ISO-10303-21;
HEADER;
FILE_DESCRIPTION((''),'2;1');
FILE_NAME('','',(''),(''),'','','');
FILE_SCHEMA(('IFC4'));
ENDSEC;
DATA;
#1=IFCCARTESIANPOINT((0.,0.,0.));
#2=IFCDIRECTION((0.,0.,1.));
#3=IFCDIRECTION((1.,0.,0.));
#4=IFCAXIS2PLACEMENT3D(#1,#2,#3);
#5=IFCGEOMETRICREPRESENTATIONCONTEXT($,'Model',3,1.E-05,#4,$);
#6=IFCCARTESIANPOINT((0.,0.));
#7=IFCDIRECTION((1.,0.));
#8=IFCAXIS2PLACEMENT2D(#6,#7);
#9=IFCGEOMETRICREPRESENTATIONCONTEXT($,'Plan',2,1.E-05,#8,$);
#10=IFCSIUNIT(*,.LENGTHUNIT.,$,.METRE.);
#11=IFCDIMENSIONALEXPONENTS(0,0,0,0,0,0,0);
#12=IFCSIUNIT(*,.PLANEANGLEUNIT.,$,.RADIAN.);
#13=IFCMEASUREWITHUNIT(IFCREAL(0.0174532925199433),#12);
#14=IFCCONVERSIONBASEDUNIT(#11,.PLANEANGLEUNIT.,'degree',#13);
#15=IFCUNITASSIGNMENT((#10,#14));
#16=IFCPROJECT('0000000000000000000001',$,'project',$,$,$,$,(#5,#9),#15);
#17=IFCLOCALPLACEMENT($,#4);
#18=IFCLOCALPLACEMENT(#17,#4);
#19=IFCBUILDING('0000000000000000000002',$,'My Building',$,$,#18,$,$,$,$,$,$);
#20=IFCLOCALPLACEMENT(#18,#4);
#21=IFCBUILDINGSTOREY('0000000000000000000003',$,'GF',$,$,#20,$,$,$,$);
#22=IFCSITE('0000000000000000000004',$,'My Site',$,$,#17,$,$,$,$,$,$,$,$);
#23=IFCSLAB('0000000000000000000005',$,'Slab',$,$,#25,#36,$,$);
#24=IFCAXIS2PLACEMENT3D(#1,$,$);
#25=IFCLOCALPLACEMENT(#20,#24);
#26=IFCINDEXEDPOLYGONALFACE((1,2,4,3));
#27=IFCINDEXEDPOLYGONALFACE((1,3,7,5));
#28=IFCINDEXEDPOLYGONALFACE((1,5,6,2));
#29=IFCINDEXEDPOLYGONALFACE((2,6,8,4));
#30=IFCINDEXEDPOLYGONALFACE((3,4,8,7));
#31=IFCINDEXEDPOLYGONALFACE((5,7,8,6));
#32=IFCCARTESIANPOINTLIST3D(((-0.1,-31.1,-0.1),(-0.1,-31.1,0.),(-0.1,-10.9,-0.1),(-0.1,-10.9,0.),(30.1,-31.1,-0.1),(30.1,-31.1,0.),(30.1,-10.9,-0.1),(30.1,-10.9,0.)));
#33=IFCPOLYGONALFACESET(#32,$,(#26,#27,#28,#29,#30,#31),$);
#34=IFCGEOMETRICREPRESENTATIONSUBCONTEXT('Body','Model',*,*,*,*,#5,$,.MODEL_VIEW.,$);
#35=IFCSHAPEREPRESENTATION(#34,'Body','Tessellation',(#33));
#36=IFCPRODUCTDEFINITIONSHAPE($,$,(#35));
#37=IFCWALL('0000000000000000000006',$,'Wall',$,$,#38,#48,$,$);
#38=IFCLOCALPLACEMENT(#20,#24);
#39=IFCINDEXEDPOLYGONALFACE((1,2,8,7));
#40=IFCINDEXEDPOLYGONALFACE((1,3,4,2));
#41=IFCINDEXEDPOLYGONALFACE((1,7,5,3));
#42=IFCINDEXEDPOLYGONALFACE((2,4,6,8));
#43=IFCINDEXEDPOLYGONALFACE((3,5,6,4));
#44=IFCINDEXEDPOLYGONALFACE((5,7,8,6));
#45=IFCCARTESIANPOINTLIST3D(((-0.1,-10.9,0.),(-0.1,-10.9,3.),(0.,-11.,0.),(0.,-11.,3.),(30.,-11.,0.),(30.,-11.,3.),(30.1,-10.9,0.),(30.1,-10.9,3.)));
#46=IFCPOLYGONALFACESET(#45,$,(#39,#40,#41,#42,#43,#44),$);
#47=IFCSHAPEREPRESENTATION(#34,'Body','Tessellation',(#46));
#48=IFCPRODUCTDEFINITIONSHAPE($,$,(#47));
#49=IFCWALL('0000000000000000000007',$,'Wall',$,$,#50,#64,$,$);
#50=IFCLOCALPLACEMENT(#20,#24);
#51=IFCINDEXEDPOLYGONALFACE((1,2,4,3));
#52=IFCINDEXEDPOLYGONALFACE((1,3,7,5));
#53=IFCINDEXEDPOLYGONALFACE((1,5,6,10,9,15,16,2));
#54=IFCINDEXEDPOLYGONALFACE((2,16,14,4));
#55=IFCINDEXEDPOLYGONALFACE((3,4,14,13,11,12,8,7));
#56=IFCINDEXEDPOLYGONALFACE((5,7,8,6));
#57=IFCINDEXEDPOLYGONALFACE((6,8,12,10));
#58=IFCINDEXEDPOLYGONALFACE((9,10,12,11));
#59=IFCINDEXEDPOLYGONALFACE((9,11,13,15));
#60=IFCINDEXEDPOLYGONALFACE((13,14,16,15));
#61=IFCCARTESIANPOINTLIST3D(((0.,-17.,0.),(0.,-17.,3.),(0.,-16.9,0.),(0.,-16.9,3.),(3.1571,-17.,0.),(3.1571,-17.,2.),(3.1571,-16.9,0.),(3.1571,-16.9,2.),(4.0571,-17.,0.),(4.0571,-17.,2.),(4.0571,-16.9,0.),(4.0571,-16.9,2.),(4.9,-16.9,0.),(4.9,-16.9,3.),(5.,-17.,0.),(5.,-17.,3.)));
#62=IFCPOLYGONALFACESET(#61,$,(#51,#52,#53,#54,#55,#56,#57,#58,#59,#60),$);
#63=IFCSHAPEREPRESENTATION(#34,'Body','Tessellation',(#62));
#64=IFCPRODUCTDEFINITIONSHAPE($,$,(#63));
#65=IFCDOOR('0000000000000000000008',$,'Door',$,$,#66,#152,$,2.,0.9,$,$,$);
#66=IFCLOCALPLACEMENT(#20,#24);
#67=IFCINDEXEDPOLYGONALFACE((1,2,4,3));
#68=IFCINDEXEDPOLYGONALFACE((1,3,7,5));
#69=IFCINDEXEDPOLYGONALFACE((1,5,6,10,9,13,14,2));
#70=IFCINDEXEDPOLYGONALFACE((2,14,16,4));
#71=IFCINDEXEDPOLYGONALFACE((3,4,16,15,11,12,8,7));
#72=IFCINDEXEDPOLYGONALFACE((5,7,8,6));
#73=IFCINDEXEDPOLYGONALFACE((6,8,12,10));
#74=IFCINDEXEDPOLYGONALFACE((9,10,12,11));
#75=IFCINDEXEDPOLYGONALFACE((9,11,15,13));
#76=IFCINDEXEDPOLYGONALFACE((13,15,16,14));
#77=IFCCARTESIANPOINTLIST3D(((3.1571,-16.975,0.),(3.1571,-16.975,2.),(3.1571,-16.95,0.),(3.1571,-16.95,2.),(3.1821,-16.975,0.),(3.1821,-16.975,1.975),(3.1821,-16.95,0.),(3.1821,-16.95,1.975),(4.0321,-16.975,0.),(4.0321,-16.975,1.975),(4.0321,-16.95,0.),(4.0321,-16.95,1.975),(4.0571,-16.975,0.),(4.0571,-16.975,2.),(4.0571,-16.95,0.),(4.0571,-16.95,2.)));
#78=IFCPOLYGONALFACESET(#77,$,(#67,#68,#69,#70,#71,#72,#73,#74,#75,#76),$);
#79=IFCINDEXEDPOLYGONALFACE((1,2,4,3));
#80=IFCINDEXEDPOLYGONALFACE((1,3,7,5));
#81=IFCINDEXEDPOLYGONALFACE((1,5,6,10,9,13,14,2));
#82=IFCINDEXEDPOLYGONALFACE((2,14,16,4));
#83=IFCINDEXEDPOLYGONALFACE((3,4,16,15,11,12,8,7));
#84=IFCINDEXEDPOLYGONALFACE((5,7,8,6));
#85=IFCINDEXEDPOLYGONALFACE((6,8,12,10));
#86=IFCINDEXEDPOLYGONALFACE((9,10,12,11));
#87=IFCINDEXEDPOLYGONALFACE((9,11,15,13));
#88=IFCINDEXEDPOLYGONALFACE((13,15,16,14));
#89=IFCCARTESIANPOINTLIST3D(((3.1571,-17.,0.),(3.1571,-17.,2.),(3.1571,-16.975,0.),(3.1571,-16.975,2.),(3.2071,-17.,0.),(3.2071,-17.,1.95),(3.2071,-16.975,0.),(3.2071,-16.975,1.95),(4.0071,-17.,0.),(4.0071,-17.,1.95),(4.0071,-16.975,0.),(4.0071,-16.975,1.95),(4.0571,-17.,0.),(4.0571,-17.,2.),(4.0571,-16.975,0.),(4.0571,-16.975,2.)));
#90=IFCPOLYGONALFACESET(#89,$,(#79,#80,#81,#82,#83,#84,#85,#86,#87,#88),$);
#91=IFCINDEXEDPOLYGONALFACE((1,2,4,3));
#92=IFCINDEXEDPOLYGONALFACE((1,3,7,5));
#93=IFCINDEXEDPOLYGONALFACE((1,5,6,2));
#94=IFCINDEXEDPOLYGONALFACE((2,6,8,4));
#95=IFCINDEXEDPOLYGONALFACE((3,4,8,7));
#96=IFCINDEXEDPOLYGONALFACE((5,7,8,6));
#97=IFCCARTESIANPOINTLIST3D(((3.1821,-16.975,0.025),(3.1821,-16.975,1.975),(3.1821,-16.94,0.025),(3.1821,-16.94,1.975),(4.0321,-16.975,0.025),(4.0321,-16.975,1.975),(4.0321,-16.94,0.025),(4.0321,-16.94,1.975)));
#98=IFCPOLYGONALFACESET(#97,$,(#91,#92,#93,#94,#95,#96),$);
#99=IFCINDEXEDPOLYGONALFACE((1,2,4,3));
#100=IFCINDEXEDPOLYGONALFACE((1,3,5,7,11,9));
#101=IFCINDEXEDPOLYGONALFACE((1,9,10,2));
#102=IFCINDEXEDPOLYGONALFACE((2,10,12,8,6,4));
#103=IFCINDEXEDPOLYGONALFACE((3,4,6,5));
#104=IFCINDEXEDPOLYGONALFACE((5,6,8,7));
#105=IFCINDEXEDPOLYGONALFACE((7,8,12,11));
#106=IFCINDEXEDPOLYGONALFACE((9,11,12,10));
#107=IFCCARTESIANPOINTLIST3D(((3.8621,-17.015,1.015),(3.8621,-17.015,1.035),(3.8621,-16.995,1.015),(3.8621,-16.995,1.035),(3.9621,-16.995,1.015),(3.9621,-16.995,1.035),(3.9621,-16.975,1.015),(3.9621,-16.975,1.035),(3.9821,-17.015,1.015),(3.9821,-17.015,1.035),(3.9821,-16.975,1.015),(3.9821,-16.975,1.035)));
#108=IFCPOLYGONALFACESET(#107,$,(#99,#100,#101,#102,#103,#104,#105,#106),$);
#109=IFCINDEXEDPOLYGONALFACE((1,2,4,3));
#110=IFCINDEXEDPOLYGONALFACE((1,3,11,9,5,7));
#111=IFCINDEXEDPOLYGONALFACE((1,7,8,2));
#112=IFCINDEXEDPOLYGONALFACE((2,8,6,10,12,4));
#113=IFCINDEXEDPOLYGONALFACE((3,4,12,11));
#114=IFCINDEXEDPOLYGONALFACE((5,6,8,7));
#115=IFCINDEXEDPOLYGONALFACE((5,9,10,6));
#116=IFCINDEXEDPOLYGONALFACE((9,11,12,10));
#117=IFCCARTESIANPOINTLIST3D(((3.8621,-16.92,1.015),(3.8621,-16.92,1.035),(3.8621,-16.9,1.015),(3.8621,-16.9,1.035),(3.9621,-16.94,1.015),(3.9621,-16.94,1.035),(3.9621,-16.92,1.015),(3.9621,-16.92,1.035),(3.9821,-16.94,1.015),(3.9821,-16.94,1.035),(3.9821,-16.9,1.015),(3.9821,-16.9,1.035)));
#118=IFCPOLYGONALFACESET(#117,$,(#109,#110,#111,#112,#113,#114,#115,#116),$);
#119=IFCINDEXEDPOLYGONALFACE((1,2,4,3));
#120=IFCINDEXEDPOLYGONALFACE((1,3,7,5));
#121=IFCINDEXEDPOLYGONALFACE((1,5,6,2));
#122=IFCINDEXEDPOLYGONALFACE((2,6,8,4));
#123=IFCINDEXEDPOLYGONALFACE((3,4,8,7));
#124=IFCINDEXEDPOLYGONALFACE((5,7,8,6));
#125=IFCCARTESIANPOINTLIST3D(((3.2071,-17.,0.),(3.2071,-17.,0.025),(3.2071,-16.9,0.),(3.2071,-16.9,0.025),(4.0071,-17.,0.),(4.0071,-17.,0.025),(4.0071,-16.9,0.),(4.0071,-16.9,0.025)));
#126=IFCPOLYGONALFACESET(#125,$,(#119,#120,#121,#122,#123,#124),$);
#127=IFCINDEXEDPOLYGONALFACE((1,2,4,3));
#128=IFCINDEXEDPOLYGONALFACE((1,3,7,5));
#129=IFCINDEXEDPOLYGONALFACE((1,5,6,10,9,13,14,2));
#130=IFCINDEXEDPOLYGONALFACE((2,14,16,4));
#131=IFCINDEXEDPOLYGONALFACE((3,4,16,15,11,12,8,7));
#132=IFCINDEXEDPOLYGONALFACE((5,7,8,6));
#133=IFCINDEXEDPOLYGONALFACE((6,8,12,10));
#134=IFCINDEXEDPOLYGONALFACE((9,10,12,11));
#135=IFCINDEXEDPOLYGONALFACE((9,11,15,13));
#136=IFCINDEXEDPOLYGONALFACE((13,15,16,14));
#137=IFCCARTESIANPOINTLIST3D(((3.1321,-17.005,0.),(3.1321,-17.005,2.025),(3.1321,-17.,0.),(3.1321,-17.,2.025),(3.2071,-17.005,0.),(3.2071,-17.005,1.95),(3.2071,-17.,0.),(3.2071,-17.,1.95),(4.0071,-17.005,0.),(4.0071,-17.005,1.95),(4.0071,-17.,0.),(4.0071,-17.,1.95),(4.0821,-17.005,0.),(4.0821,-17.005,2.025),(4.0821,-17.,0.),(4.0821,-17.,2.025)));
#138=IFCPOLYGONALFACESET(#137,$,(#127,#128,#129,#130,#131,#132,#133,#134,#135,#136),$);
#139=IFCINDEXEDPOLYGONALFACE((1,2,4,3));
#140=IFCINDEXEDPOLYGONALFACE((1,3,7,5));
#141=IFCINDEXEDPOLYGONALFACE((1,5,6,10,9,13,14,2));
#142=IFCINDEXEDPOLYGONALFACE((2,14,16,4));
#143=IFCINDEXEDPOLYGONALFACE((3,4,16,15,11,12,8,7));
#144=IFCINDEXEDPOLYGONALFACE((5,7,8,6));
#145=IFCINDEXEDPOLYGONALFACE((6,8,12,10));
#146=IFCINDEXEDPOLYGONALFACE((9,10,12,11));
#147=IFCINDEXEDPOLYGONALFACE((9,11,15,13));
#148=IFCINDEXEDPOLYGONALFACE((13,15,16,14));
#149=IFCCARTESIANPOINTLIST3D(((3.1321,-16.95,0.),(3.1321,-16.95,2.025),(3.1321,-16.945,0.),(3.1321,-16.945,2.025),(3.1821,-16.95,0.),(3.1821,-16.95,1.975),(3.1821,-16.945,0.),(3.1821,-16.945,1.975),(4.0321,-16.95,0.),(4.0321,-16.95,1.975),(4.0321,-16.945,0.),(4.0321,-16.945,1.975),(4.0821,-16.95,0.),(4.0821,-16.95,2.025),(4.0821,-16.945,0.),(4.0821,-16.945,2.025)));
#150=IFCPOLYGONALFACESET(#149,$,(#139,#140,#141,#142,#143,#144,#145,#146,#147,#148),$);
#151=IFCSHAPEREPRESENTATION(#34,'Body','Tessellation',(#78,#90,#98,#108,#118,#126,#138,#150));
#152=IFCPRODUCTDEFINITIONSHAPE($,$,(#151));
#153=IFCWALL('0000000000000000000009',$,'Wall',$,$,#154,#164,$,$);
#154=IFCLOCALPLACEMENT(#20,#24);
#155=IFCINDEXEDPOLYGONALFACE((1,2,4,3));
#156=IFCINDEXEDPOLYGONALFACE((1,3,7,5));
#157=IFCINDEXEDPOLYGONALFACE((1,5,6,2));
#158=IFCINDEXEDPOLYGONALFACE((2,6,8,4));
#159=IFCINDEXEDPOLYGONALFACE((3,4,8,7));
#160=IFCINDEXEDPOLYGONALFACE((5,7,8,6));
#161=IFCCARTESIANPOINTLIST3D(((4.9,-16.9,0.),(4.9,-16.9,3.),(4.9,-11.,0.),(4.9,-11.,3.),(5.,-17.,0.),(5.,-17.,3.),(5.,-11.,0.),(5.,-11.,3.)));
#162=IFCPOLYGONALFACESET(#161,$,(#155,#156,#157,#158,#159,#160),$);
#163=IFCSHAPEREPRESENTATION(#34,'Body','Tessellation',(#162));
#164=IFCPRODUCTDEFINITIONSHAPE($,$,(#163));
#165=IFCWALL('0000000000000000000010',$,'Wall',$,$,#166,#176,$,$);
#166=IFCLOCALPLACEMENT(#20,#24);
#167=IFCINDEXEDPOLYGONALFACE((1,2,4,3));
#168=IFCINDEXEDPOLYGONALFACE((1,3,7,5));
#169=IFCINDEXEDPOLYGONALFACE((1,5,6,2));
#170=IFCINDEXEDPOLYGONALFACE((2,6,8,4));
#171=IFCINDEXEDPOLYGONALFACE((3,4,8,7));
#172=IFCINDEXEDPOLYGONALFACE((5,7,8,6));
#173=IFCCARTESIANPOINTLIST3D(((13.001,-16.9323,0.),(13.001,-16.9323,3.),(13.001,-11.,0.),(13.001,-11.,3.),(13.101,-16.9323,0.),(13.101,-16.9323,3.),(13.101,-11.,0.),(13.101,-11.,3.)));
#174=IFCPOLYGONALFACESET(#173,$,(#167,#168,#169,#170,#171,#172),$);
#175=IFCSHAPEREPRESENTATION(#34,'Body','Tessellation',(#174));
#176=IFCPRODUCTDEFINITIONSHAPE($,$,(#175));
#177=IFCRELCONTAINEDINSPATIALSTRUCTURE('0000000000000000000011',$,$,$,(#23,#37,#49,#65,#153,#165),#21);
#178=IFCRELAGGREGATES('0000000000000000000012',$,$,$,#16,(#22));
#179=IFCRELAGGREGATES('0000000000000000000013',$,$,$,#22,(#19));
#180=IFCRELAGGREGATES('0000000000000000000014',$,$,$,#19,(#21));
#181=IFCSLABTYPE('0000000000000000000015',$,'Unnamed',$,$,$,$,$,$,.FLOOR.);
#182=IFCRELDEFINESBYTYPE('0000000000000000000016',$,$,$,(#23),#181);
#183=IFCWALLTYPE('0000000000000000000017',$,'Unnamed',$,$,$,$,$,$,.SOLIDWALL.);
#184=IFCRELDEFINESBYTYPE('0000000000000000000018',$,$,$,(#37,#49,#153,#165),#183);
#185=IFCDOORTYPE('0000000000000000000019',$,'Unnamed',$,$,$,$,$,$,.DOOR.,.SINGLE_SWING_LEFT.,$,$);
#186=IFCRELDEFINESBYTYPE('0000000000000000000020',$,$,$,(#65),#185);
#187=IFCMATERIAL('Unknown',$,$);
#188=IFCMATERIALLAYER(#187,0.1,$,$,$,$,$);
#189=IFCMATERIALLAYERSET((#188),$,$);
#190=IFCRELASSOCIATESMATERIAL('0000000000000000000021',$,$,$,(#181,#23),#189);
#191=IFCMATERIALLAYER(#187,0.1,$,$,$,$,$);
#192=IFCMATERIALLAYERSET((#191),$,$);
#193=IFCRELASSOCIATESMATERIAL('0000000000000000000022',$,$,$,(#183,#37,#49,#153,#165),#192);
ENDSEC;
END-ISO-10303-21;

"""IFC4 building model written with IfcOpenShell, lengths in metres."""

from ifc_helpers import new_model, entity, si_unit, converted_unit, frame, origin_with_axes, origin_2d_with_axis, place, context, subcontext, project, spatial, line, indexed_curve, outline, extrude, shape, source, transform, mapped, material, layer, layer_set, layer_usage, type_object, type_shapes, element, fill, save


model = new_model("IFC4")

# Units and contexts
model_context = context("Model", 3, precision=1e-05, world=origin_with_axes())
plan_context = context("Plan", 2, precision=1e-05, world=origin_2d_with_axis())
body_context_1 = subcontext(model_context, "Body", "Model", "MODEL_VIEW")
body_context_2 = subcontext(plan_context, "Body", "Plan", "PLAN_VIEW")
ifc_project = project(units=[si_unit("LENGTHUNIT", "METRE"), converted_unit("PLANEANGLEUNIT", "degree", entity("IfcReal", 0.0174532925199433), si_unit("PLANEANGLEUNIT", "RADIAN"), dimensions=[0, 0, 0, 0, 0, 0, 0])], contexts=[model_context, plan_context])

# Site, building, storey
site_placement = place(None, origin_with_axes())
site = spatial("IfcSite", under=ifc_project, at=site_placement, Name="My Site")
building_placement = place(site_placement, origin_with_axes())
building = spatial("IfcBuilding", under=site, at=building_placement, Name="My Building")
storey_placement = place(building_placement, origin_with_axes())
storey = spatial("IfcBuildingStorey", under=building, at=storey_placement, Name="GF")

# Slab
ifc_material = material(Name="Unknown")
ifc_layer_1 = layer(ifc_material, 0.1)
ifc_layer_set_1 = layer_set([ifc_layer_1])
ifc_layer_usage_1 = layer_usage(ifc_layer_set_1, "AXIS3", "POSITIVE", -0.1)
slab_type = type_object("IfcSlabType", Name="Unnamed", PredefinedType="FLOOR", material=ifc_layer_set_1)
slab_1_placement = place(storey_placement, frame((-0.1, -10.9, 0.0), z_axis=(0.0, 0.0, 1.0), x_axis=(1.0, 0.0, 0.0)))
element("IfcSlab", 1, at=slab_1_placement, inside=storey, type_object=slab_type, material=ifc_layer_usage_1, Name="Slab", context=body_context_1, shape_type="SweptSolid", body=[
    extrude(outline(indexed_curve([(0.0, 0.0), (30.2, 0.0), (30.2, -20.2), (0.0, -20.2), (0.0, 0.0)])), frame((0.0, 0.0, -0.1), z_axis=(0.0, 0.0, 1.0), x_axis=(1.0, 0.0, 0.0)), (0.0, 0.0, 1.0), 0.1),
])

# Wall
ifc_layer_2 = layer(ifc_material, 0.1)
ifc_layer_set_2 = layer_set([ifc_layer_2])
ifc_layer_usage_2 = layer_usage(ifc_layer_set_2, "AXIS2", "POSITIVE", 0.0)
wall_type = type_object("IfcWallType", Name="Unnamed", PredefinedType="SOLIDWALL", material=ifc_layer_set_2)
wall_1_placement = place(storey_placement, frame((0.0, -11.0, 0.0), z_axis=(0.0, 0.0, 1.0), x_axis=(1.0, 0.0, 0.0)))
element("IfcWall", 2, at=wall_1_placement, inside=storey, type_object=wall_type, material=ifc_layer_usage_2, Name="Wall", context=body_context_1, shape_type="SweptSolid", body=[
    extrude(outline(indexed_curve([(0.0, 0.0), (-0.1, 0.1), (30.1, 0.1), (30.0, 0.0)], segments=[line(1, 2, 3, 4, 1)])), origin_with_axes(), (0.0, 0.0, 1.0), 3.0),
])

# Wall, opening, door
ifc_layer_usage_3 = layer_usage(ifc_layer_set_2, "AXIS2", "POSITIVE", 0.0)
wall_2_placement = place(storey_placement, frame((0.0, -17.0, 0.0), z_axis=(0.0, 0.0, 1.0), x_axis=(1.0, 0.0, 0.0)))
wall_2 = element("IfcWall", 3, at=wall_2_placement, inside=storey, type_object=wall_type, material=ifc_layer_usage_3, Name="Wall", context=body_context_1, shape_type="SweptSolid", body=[
    extrude(outline(indexed_curve([(0.0, 0.0), (0.0, 0.1), (4.9, 0.1), (5.0, 0.0)], segments=[line(1, 2, 3, 4, 1)])), origin_with_axes(), (0.0, 0.0, 1.0), 3.0),
])
shared_shape_1 = source(origin_with_axes(), body_context_1, "Body", "SweptSolid", [
    extrude(outline(indexed_curve([(0.0, 0.0), (0.9, 0.0), (0.9, 2.0), (0.0, 2.0)], segments=[line(1, 2, 3, 4, 1)])), frame((0.0, -0.6, 0.0), z_axis=(0.0, -1.0, 0.0), x_axis=(1.0, 0.0, 0.0)), (0.0, 0.0, -1.0), 1.2),
])
opening_1_placement = place(wall_2_placement, frame((3.1571, 0.0, 0.0), z_axis=(0.0, 0.0, 1.0), x_axis=(1.0, 0.0, 0.0)))
opening_1 = element("IfcOpeningElement", 4, at=opening_1_placement, cuts=wall_2, PredefinedType="OPENING", context=body_context_1, shape_type="MappedRepresentation", body=[
    mapped(shared_shape_1, transform((0.0, 0.0, 0.0), x_axis=(1.0, 0.0, 0.0), y_axis=(0.0, 1.0, 0.0), z_axis=(0.0, 0.0, 1.0), scale=1.0)),
])
door_type = type_object("IfcDoorType", Name="Unnamed", OperationType="SINGLE_SWING_LEFT", PredefinedType="DOOR")
shared_shape_2 = source(origin_with_axes(), body_context_1, "Body", "SweptSolid", [
    extrude(outline(indexed_curve([(0.0, 0.0), (0.0, 2.0), (0.9, 2.0), (0.9, 0.0), (0.875, 0.0), (0.875, 1.975), (0.025, 1.975), (0.025, 0.0)], segments=[line(1, 2, 3, 4, 5, 6, 7, 8, 1)])), frame((0.0, 0.025, 0.0), z_axis=(0.0, -1.0, 0.0), x_axis=(1.0, 0.0, 0.0)), (0.0, 0.0, -1.0), 0.025),
    extrude(outline(indexed_curve([(0.0, 0.0), (0.0, 2.0), (0.9, 2.0), (0.9, 0.0), (0.85, 0.0), (0.85, 1.95), (0.05, 1.95), (0.05, 0.0)], segments=[line(1, 2, 3, 4, 5, 6, 7, 8, 1)])), frame((0.0, 0.0, 0.0), z_axis=(0.0, -1.0, 0.0), x_axis=(1.0, 0.0, 0.0)), (0.0, 0.0, -1.0), 0.025),
    extrude(outline(indexed_curve([(0.0, 0.0), (0.85, 0.0), (0.85, 0.035), (0.0, 0.035)], segments=[line(1, 2, 3, 4, 1)])), frame((0.025, 0.025, 0.025), z_axis=(0.0, 0.0, 1.0), x_axis=(1.0, 0.0, 0.0)), (0.0, 0.0, 1.0), 1.95),
    extrude(outline(indexed_curve([(0.0, 0.0), (0.0, -0.04), (-0.12, -0.04), (-0.12, -0.02), (-0.02, -0.02), (-0.02, 0.0)], segments=[line(1, 2, 3, 4, 5, 6, 1)])), frame((0.825, 0.025, 1.015), z_axis=(0.0, 0.0, 1.0), x_axis=(1.0, 0.0, 0.0)), (0.0, 0.0, 1.0), 0.02),
    extrude(outline(indexed_curve([(0.0, 0.0), (0.0, 0.04), (-0.12, 0.04), (-0.12, 0.02), (-0.02, 0.02), (-0.02, 0.0)], segments=[line(1, 2, 3, 4, 5, 6, 1)])), frame((0.825, 0.06, 1.015), z_axis=(0.0, 0.0, 1.0), x_axis=(1.0, 0.0, 0.0)), (0.0, 0.0, 1.0), 0.02),
    extrude(outline(indexed_curve([(0.0, 0.0), (0.8, 0.0), (0.8, 0.1), (0.0, 0.1)], segments=[line(1, 2, 3, 4, 1)])), frame((0.05, 0.0, 0.0), z_axis=(0.0, 0.0, 1.0), x_axis=(1.0, 0.0, 0.0)), (0.0, 0.0, 1.0), 0.025),
    extrude(outline(indexed_curve([(0.0, 0.0), (0.0, 2.025), (0.95, 2.025), (0.95, 0.0), (0.875, 0.0), (0.875, 1.95), (0.075, 1.95), (0.075, 0.0)], segments=[line(1, 2, 3, 4, 5, 6, 7, 8, 1)])), frame((-0.025, -0.005, 0.0), z_axis=(0.0, -1.0, 0.0), x_axis=(1.0, 0.0, 0.0)), (0.0, 0.0, -1.0), 0.005),
    extrude(outline(indexed_curve([(0.0, 0.0), (0.0, 2.025), (0.95, 2.025), (0.95, 0.0), (0.9, 0.0), (0.9, 1.975), (0.05, 1.975), (0.05, 0.0)], segments=[line(1, 2, 3, 4, 5, 6, 7, 8, 1)])), frame((-0.025, 0.05, 0.0), z_axis=(0.0, -1.0, 0.0), x_axis=(1.0, 0.0, 0.0)), (0.0, 0.0, -1.0), 0.005),
])
shared_shape_3 = source(origin_with_axes(), body_context_2, "Body", "Curve2D", [
    entity("IfcIndexedPolyCurve", entity("IfcCartesianPointList2D", [[0.0, 0.0], [0.0, 0.05], [0.025, 0.05], [0.025, 0.025], [0.05, 0.025], [0.05, 0.0]]), [entity("IfcLineIndex", [1, 2, 3, 4, 5, 6, 1])]),
    entity("IfcIndexedPolyCurve", entity("IfcCartesianPointList2D", [[0.9, 0.0], [0.9, 0.05], [0.875, 0.05], [0.875, 0.025], [0.85, 0.025], [0.85, 0.0]]), [entity("IfcLineIndex", [1, 2, 3, 4, 5, 6, 1])]),
    entity("IfcTrimmedCurve", entity("IfcEllipse", entity("IfcAxis2Placement2D", entity("IfcCartesianPoint", [0.06, 0.05]), entity("IfcDirection", [1.0, 0.0])), 0.815, 0.85), [entity("IfcCartesianPoint", [0.875, 0.05])], [entity("IfcCartesianPoint", [0.06, 0.9])], True, "CARTESIAN"),
    entity("IfcIndexedPolyCurve", entity("IfcCartesianPointList2D", [[0.025, 0.05], [0.06, 0.05], [0.06, 0.9], [0.025, 0.9]]), [entity("IfcLineIndex", [1, 2, 3, 4, 1])]),
])
type_shapes(door_type, [shared_shape_2, shared_shape_3])
door_1_placement = place(opening_1_placement, origin_with_axes())
door_1 = element("IfcDoor", 5, at=door_1_placement, inside=storey, type_object=door_type, Name="Door", OverallHeight=2.0, OverallWidth=0.9, shapes=[
    shape(body_context_1, "Body", "MappedRepresentation", [mapped(shared_shape_2, transform((0.0, 0.0, 0.0), x_axis=(1.0, 0.0, 0.0), y_axis=(0.0, 1.0, 0.0), z_axis=(0.0, 0.0, 1.0), scale=1.0))]),
    shape(body_context_2, "Body", "MappedRepresentation", [mapped(shared_shape_3, transform((0.0, 0.0, 0.0), x_axis=(1.0, 0.0, 0.0), y_axis=(0.0, 1.0, 0.0), z_axis=(0.0, 0.0, 1.0), scale=1.0))]),
])
fill(opening_1, door_1)

# Wall
ifc_layer_usage_4 = layer_usage(ifc_layer_set_2, "AXIS2", "POSITIVE", 0.0)
wall_3_placement = place(storey_placement, frame((5.0, -17.0, 0.0), z_axis=(0.0, 0.0, 1.0), x_axis=(0.0, 1.0, 0.0)))
element("IfcWall", 6, at=wall_3_placement, inside=storey, type_object=wall_type, material=ifc_layer_usage_4, Name="Wall", context=body_context_1, shape_type="SweptSolid", body=[
    extrude(outline(indexed_curve([(0.0, 0.0), (0.1, 0.1), (6.0, 0.1), (6.0, 0.0)], segments=[line(1, 2, 3, 4, 1)])), origin_with_axes(), (0.0, 0.0, 1.0), 3.0),
])

# Wall
ifc_layer_usage_5 = layer_usage(ifc_layer_set_2, "AXIS2", "POSITIVE", 0.0)
wall_4_placement = place(storey_placement, frame((13.101, -16.9323, 0.0), z_axis=(0.0, 0.0, 1.0), x_axis=(0.0, 1.0, 0.0)))
element("IfcWall", 7, at=wall_4_placement, inside=storey, type_object=wall_type, material=ifc_layer_usage_5, Name="Wall", context=body_context_1, shape_type="SweptSolid", body=[
    extrude(outline(indexed_curve([(0.0, 0.0), (0.0, 0.1), (5.9323, 0.1), (5.9323, 0.0)], segments=[line(1, 2, 3, 4, 1)])), origin_with_axes(), (0.0, 0.0, 1.0), 3.0),
])

save(model, "model.ifc")
